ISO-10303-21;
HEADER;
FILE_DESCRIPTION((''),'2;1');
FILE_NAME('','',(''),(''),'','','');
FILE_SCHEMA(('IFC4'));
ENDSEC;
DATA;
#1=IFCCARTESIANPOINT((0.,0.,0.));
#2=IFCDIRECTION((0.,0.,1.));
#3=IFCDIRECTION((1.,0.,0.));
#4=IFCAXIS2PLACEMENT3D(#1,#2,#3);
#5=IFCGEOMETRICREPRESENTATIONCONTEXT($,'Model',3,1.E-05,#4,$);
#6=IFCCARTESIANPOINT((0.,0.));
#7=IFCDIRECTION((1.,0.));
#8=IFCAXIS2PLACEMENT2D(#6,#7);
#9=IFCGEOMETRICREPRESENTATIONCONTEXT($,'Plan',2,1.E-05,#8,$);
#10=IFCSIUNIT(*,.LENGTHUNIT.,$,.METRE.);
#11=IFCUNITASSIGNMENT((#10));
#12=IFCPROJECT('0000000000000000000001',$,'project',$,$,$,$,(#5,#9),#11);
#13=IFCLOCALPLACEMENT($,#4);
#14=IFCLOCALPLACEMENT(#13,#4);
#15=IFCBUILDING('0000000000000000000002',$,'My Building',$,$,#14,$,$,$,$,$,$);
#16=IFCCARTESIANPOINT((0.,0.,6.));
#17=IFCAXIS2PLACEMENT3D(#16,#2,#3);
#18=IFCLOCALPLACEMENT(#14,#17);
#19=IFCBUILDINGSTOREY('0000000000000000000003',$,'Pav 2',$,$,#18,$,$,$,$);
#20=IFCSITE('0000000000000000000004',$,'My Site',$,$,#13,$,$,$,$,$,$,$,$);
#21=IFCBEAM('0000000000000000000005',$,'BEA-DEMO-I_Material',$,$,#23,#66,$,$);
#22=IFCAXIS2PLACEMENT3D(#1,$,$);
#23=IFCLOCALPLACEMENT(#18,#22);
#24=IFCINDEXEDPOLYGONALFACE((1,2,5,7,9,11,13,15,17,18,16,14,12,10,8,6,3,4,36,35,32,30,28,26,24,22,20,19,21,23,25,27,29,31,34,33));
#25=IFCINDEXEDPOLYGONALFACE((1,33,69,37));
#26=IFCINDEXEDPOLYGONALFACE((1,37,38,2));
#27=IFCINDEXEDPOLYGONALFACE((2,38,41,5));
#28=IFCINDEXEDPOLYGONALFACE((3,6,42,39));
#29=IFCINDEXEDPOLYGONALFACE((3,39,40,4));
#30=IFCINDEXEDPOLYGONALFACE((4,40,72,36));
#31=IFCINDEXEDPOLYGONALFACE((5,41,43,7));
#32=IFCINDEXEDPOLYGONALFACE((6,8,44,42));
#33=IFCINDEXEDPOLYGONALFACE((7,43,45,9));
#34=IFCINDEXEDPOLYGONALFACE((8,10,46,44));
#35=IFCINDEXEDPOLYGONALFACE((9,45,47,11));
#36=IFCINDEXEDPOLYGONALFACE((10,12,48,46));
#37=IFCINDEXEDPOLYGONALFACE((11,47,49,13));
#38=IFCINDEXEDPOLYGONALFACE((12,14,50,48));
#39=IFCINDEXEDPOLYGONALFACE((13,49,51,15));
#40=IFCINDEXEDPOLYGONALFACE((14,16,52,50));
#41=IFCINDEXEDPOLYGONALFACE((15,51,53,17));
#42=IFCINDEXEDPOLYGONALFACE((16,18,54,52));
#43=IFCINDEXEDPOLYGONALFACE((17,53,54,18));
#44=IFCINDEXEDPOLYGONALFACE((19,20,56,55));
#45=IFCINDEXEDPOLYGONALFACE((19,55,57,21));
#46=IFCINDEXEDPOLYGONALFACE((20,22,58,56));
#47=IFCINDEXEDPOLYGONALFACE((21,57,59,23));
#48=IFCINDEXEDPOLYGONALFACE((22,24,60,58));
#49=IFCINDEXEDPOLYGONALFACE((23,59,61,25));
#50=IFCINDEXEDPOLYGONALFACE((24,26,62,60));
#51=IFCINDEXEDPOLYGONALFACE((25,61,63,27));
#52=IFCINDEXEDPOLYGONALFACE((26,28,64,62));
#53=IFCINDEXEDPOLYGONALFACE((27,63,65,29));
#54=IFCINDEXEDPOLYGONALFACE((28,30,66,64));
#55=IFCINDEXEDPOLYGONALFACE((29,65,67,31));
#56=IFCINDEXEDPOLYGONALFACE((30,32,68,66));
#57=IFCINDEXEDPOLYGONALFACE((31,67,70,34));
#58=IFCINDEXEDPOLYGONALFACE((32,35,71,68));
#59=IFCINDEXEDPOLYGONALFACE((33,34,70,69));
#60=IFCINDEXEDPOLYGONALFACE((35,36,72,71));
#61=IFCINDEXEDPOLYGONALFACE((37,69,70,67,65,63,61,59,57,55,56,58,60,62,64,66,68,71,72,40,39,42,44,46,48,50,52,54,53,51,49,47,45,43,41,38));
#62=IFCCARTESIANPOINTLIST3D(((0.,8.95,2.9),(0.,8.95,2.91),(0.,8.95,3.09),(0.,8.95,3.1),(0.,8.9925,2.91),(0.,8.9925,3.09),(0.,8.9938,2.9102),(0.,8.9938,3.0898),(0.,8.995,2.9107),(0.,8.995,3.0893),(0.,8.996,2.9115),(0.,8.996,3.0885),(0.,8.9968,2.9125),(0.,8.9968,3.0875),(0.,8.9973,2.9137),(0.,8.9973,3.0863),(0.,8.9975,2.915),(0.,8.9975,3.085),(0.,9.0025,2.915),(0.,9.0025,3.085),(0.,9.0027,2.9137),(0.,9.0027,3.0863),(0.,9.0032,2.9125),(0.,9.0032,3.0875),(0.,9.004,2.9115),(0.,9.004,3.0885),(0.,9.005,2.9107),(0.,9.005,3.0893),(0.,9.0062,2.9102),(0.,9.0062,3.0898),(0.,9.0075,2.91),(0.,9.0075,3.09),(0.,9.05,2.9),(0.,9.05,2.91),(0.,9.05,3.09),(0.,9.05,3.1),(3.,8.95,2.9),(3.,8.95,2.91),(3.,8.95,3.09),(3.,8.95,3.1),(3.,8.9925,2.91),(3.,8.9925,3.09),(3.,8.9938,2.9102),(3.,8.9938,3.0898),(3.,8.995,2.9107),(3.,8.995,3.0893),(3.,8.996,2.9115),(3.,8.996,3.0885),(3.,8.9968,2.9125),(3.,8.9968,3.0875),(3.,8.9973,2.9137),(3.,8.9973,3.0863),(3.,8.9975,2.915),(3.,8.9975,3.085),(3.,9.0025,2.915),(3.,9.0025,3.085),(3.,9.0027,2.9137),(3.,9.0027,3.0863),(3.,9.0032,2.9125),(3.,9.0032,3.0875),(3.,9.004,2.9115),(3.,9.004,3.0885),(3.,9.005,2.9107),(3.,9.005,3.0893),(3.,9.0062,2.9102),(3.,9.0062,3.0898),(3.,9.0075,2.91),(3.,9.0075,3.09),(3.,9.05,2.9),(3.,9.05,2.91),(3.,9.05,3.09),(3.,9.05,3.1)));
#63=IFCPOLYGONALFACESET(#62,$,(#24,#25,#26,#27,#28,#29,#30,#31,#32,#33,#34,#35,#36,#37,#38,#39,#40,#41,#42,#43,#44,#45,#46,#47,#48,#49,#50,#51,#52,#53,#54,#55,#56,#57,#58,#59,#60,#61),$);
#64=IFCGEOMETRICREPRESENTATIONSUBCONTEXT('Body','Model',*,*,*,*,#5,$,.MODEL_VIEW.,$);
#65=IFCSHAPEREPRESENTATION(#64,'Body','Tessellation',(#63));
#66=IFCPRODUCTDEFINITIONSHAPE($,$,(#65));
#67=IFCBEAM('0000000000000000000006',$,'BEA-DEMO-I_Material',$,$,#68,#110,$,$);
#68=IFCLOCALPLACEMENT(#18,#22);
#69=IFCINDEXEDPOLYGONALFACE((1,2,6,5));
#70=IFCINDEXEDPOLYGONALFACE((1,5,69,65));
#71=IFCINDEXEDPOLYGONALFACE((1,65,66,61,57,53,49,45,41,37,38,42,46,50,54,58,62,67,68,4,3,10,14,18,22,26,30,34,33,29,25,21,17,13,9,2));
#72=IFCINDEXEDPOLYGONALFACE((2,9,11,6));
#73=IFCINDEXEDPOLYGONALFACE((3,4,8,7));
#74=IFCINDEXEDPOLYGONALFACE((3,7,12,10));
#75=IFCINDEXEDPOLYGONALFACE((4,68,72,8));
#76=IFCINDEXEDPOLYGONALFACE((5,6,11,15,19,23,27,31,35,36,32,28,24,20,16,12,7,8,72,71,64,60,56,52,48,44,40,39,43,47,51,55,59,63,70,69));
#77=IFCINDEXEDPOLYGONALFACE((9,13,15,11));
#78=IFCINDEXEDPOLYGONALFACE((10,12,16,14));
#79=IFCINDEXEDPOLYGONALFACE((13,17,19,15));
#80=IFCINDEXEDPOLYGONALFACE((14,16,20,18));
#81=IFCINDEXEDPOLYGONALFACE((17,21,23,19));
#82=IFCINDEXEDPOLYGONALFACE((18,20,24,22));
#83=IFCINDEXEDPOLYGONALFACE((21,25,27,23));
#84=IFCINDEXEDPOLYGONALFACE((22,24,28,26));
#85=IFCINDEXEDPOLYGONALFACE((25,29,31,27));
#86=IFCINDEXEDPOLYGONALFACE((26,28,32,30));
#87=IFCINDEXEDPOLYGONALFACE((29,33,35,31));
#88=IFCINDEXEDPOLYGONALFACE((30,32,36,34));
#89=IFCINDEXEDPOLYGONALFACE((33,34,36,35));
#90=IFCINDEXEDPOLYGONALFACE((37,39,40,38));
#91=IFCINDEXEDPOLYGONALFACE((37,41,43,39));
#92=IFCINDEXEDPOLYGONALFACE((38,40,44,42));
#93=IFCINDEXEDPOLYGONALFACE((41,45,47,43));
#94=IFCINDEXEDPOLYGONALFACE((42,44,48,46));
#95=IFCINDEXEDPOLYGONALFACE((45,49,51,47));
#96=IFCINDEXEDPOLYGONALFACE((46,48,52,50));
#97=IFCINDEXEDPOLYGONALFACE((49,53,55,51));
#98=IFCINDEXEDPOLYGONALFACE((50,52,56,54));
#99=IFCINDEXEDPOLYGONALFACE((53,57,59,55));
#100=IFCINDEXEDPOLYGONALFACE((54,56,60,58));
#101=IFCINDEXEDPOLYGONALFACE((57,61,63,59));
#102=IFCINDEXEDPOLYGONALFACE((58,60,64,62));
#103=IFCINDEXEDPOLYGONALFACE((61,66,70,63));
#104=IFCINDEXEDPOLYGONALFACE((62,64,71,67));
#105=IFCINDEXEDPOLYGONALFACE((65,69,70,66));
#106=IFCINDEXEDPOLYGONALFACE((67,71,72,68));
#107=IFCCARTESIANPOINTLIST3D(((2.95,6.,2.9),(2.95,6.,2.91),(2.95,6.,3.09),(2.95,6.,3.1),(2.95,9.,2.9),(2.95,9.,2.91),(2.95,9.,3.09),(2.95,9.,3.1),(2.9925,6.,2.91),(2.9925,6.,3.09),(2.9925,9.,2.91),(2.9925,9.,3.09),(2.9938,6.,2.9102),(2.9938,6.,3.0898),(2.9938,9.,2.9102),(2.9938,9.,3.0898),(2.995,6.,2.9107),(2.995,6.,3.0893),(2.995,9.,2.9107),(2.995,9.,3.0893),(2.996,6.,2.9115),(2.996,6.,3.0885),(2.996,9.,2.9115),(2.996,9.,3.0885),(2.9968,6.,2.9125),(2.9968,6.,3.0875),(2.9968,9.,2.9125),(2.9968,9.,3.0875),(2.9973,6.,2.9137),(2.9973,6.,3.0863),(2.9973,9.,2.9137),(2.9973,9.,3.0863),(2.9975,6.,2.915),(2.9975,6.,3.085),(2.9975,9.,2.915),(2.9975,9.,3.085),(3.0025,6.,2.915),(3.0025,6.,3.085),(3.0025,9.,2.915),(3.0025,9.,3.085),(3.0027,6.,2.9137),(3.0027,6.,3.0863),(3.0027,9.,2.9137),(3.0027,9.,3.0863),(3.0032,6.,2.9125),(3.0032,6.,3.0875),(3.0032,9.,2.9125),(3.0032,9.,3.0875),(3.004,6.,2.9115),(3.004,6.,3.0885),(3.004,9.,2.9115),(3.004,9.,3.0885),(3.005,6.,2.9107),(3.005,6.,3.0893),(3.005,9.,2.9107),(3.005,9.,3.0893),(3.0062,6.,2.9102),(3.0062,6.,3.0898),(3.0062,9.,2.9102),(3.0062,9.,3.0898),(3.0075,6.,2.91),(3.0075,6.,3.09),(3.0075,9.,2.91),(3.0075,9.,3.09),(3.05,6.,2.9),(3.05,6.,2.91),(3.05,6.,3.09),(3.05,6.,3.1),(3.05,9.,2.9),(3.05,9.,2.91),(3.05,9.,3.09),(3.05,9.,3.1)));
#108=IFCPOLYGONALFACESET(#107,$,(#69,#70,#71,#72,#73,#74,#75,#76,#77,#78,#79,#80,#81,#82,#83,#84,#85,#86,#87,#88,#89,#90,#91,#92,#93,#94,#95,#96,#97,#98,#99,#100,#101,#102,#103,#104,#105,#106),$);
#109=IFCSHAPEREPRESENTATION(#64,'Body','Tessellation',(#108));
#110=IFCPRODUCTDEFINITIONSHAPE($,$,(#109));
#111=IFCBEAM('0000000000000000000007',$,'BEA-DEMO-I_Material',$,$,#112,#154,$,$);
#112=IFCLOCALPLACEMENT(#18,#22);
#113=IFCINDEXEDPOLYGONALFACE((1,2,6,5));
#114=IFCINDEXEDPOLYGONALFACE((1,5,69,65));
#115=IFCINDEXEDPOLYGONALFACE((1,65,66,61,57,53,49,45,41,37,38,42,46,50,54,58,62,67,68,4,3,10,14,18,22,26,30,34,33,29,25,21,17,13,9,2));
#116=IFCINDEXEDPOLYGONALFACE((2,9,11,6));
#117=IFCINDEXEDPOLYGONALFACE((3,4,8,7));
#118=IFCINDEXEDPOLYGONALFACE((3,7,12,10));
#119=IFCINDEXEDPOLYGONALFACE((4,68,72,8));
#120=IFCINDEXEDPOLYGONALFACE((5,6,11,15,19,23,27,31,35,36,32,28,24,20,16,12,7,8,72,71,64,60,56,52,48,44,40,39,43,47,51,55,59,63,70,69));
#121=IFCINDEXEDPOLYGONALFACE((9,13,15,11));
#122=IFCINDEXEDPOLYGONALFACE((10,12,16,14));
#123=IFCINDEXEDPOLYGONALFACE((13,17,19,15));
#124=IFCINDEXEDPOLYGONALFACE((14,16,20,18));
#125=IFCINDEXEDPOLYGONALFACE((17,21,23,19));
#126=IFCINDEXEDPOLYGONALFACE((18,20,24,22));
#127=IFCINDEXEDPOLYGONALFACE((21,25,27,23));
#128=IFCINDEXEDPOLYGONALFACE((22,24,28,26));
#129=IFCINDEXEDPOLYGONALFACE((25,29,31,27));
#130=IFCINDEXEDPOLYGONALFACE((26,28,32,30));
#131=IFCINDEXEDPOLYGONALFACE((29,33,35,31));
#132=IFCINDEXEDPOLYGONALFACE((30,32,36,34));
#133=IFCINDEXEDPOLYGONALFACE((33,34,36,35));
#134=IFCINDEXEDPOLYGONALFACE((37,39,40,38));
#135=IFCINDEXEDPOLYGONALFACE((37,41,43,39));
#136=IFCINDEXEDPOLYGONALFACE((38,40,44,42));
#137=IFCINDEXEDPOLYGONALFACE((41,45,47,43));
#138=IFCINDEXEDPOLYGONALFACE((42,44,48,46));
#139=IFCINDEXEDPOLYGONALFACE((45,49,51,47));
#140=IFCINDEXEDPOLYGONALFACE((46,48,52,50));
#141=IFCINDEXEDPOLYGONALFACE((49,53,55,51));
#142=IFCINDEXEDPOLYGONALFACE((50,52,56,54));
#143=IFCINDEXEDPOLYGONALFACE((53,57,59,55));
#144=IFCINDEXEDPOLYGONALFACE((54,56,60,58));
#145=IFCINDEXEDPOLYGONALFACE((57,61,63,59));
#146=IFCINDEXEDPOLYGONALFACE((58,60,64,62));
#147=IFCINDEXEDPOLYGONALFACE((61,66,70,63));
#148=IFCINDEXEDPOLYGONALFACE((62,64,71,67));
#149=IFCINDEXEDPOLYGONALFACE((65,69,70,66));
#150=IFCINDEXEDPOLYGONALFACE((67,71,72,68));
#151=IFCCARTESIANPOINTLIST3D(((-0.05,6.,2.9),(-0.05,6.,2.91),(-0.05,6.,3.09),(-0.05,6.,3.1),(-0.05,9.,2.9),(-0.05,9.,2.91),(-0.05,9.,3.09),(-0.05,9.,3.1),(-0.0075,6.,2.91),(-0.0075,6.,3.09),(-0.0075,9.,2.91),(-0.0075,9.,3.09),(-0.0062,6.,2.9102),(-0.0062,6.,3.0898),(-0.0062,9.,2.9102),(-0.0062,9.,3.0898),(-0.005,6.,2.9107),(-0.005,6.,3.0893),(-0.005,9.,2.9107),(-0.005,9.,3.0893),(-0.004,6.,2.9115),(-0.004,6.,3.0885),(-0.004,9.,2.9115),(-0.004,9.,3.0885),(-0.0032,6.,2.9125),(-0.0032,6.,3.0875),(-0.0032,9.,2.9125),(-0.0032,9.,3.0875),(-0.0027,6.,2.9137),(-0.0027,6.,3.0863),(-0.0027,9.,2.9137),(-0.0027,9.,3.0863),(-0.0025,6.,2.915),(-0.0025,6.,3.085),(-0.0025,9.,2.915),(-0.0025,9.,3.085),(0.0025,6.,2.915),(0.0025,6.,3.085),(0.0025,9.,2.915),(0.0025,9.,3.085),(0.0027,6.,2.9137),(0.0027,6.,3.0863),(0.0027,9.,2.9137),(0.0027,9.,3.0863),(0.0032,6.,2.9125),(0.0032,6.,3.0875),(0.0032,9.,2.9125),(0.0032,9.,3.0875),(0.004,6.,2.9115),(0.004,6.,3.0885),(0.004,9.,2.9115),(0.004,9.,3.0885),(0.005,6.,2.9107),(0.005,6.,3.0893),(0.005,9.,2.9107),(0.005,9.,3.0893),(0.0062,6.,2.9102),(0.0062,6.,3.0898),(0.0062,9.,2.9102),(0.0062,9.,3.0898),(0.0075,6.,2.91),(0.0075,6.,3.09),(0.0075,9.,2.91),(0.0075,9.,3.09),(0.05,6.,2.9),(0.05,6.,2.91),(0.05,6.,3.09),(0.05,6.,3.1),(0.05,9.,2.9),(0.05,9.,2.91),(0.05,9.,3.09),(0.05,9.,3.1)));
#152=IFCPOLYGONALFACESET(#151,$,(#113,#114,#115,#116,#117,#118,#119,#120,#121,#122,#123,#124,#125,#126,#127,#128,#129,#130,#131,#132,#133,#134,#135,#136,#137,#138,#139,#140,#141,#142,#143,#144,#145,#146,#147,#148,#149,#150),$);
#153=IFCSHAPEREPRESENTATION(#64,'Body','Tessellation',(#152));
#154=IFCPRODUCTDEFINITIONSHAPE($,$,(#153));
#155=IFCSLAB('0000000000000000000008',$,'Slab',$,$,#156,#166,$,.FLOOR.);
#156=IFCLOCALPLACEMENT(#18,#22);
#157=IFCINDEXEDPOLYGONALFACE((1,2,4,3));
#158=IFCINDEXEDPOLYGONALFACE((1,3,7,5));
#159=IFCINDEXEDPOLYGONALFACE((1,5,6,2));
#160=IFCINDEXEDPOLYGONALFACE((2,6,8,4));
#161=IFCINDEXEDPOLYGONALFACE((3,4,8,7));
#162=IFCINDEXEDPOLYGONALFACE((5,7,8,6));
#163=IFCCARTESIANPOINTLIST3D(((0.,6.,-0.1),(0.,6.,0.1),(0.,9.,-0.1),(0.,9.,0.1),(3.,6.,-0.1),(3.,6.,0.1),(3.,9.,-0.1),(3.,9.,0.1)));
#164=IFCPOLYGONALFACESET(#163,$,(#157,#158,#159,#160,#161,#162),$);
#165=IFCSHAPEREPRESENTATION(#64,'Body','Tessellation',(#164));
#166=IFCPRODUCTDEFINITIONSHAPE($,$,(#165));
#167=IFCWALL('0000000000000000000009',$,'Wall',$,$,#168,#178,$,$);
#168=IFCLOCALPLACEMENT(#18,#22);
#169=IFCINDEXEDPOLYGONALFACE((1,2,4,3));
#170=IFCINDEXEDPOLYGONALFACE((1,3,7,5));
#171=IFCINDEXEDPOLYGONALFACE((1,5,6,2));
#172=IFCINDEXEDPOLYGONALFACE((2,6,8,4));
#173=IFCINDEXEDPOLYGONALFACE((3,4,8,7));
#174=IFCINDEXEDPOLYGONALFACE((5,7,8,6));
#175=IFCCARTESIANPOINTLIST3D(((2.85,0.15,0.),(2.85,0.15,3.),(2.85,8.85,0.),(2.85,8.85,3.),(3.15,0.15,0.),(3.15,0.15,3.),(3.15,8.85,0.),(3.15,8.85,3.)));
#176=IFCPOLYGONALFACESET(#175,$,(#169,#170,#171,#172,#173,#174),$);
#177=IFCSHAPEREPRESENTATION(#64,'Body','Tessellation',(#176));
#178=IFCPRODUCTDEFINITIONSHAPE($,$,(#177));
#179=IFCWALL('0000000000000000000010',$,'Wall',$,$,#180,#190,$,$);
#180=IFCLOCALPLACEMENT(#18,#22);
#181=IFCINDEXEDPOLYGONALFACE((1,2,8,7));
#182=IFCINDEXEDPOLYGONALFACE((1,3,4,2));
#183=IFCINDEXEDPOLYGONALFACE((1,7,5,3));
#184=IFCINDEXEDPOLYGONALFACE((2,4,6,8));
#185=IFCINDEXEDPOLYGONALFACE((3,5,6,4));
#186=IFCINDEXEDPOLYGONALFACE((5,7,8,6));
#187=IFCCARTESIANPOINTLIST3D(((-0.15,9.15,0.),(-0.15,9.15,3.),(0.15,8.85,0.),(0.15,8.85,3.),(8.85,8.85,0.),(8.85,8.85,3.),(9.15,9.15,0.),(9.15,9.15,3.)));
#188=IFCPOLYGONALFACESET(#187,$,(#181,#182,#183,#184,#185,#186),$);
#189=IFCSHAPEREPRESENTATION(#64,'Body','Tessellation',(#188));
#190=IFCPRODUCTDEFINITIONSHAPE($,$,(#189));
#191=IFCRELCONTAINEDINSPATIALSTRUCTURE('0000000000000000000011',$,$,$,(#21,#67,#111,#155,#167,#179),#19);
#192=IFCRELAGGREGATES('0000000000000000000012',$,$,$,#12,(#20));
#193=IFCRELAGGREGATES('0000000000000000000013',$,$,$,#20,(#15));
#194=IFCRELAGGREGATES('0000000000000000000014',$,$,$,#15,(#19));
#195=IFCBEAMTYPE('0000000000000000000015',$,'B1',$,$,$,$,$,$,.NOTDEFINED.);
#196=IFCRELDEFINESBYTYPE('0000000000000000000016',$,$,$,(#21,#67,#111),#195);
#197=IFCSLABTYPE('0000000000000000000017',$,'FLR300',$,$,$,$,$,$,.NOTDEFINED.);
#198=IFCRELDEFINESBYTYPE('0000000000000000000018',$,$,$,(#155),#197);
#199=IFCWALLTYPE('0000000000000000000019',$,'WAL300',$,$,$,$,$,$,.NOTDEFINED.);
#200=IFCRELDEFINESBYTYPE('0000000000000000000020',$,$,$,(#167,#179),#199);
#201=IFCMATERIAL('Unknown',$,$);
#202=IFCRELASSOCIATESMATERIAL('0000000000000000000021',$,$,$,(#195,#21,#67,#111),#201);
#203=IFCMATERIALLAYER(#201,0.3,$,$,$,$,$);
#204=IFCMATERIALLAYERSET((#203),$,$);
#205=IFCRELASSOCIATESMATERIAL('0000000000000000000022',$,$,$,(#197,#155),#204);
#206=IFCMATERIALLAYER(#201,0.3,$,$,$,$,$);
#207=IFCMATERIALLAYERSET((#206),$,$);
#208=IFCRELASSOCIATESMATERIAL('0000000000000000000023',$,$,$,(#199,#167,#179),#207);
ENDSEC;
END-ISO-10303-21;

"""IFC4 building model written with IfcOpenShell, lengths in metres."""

from ifc_helpers import new_model, si_unit, frame, origin, origin_with_axes, origin_2d_with_axis, place, context, subcontext, project, spatial, polyline, line, indexed_curve, i_section, outline, extrude, material, layer, layer_set, layer_usage, material_profile, profile_set, profile_usage, type_object, element, save


model = new_model("IFC4")

# Units and contexts
model_context = context("Model", 3, precision=1e-05, world=origin_with_axes())
plan_context = context("Plan", 2, precision=1e-05, world=origin_2d_with_axis())
body_context = subcontext(model_context, "Body", "Model", "MODEL_VIEW")
ifc_project = project(units=[si_unit("LENGTHUNIT", "METRE")], contexts=[model_context, plan_context])

# Site, building, storey
site_placement = place(None, origin_with_axes())
site = spatial("IfcSite", under=ifc_project, at=site_placement, Name="My Site")
building_placement = place(site_placement, origin_with_axes())
building = spatial("IfcBuilding", under=site, at=building_placement, Name="My Building")
storey_placement = place(building_placement, frame((0.0, 0.0, 6.0), z_axis=(0.0, 0.0, 1.0), x_axis=(1.0, 0.0, 0.0)))
storey = spatial("IfcBuildingStorey", under=building, at=storey_placement, Name="Pav 2")

# Beams
ifc_material = material(Name="Unknown")
ifc_material_profile = material_profile(ifc_material, i_section(OverallWidth=0.1, OverallDepth=0.2, WebThickness=0.005, FlangeThickness=0.01, FilletRadius=0.005))
ifc_profile_set = profile_set([ifc_material_profile])
beam_type = type_object("IfcBeamType", Name="B1", PredefinedType="NOTDEFINED", material=ifc_profile_set)
ifc_profile_usage_1 = profile_usage(ifc_profile_set, cardinal=5)
beam_1_placement = place(storey_placement, frame((0.0, 9.0, 3.0), z_axis=(1.0, 0.0, 0.0), x_axis=(0.0, 1.0, 0.0)))
element("IfcBeam", 1, at=beam_1_placement, inside=storey, type_object=beam_type, material=ifc_profile_usage_1, Name="BEA-DEMO-I_Material", context=body_context, shape_type="SweptSolid", body=[
    extrude(i_section(OverallWidth=0.1, OverallDepth=0.2, WebThickness=0.005, FlangeThickness=0.01, FilletRadius=0.005), origin(), (0.0, 0.0, 1.0), 3.0),
])
ifc_profile_usage_2 = profile_usage(ifc_profile_set, cardinal=5)
beam_2_placement = place(storey_placement, frame((3.0, 9.0, 3.0), z_axis=(0.0, -1.0, 0.0), x_axis=(1.0, 0.0, 0.0)))
element("IfcBeam", 2, at=beam_2_placement, inside=storey, type_object=beam_type, material=ifc_profile_usage_2, Name="BEA-DEMO-I_Material", context=body_context, shape_type="SweptSolid", body=[
    extrude(i_section(OverallWidth=0.1, OverallDepth=0.2, WebThickness=0.005, FlangeThickness=0.01, FilletRadius=0.005), origin(), (0.0, 0.0, 1.0), 3.0),
])
ifc_profile_usage_3 = profile_usage(ifc_profile_set, cardinal=5)
beam_3_placement = place(storey_placement, frame((0.0, 6.0, 3.0), z_axis=(0.0, 1.0, 0.0), x_axis=(-1.0, 0.0, 0.0)))
element("IfcBeam", 3, at=beam_3_placement, inside=storey, type_object=beam_type, material=ifc_profile_usage_3, Name="BEA-DEMO-I_Material", context=body_context, shape_type="SweptSolid", body=[
    extrude(i_section(OverallWidth=0.1, OverallDepth=0.2, WebThickness=0.005, FlangeThickness=0.01, FilletRadius=0.005), origin(), (0.0, 0.0, 1.0), 3.0),
])

# Slab
ifc_layer_1 = layer(ifc_material, 0.3)
ifc_layer_set_1 = layer_set([ifc_layer_1])
ifc_layer_usage_1 = layer_usage(ifc_layer_set_1, "AXIS3", "POSITIVE", 0.0)
slab_type = type_object("IfcSlabType", Name="FLR300", PredefinedType="NOTDEFINED", material=ifc_layer_set_1)
slab_placement = place(storey_placement, frame((1.5, 7.5, -0.1), z_axis=(0.0, 0.0, 1.0), x_axis=(1.0, 0.0, 0.0)))
element("IfcSlab", 4, at=slab_placement, inside=storey, type_object=slab_type, material=ifc_layer_usage_1, Name="Slab", PredefinedType="FLOOR", context=body_context, shape_type="SweptSolid", body=[
    extrude(outline(polyline([(1.5, 1.5), (-1.5, 1.5), (-1.5, -1.5), (1.5, -1.5), (1.5, 1.5)])), origin(), (0.0, 0.0, 1.0), 0.2),
])

# Walls
ifc_layer_2 = layer(ifc_material, 0.3)
ifc_layer_set_2 = layer_set([ifc_layer_2])
ifc_layer_usage_2 = layer_usage(ifc_layer_set_2, "AXIS2", "POSITIVE", -0.15)
wall_type = type_object("IfcWallType", Name="WAL300", PredefinedType="NOTDEFINED", material=ifc_layer_set_2)
wall_1_placement = place(storey_placement, frame((3.0, 9.0, 0.0), z_axis=(0.0, 0.0, 1.0), x_axis=(0.0, -1.0, 0.0)))
element("IfcWall", 5, at=wall_1_placement, inside=storey, type_object=wall_type, material=ifc_layer_usage_2, Name="Wall", context=body_context, shape_type="SweptSolid", body=[
    extrude(outline(indexed_curve([(0.15, -0.15), (0.15, 0.15), (8.85, 0.15), (8.85, -0.15)], segments=[line(1, 2, 3, 4, 1)])), origin_with_axes(), (0.0, 0.0, 1.0), 3.0),
])
ifc_layer_usage_3 = layer_usage(ifc_layer_set_2, "AXIS2", "POSITIVE", -0.15)
wall_2_placement = place(storey_placement, frame((0.0, 9.0, 0.0), z_axis=(0.0, 0.0, 1.0), x_axis=(1.0, 0.0, 0.0)))
element("IfcWall", 6, at=wall_2_placement, inside=storey, type_object=wall_type, material=ifc_layer_usage_3, Name="Wall", context=body_context, shape_type="SweptSolid", body=[
    extrude(outline(indexed_curve([(0.15, -0.15), (-0.15, 0.15), (9.15, 0.15), (8.85, -0.15)], segments=[line(1, 2, 3, 4, 1)])), origin_with_axes(), (0.0, 0.0, 1.0), 3.0),
])

save(model, "model.ifc")
